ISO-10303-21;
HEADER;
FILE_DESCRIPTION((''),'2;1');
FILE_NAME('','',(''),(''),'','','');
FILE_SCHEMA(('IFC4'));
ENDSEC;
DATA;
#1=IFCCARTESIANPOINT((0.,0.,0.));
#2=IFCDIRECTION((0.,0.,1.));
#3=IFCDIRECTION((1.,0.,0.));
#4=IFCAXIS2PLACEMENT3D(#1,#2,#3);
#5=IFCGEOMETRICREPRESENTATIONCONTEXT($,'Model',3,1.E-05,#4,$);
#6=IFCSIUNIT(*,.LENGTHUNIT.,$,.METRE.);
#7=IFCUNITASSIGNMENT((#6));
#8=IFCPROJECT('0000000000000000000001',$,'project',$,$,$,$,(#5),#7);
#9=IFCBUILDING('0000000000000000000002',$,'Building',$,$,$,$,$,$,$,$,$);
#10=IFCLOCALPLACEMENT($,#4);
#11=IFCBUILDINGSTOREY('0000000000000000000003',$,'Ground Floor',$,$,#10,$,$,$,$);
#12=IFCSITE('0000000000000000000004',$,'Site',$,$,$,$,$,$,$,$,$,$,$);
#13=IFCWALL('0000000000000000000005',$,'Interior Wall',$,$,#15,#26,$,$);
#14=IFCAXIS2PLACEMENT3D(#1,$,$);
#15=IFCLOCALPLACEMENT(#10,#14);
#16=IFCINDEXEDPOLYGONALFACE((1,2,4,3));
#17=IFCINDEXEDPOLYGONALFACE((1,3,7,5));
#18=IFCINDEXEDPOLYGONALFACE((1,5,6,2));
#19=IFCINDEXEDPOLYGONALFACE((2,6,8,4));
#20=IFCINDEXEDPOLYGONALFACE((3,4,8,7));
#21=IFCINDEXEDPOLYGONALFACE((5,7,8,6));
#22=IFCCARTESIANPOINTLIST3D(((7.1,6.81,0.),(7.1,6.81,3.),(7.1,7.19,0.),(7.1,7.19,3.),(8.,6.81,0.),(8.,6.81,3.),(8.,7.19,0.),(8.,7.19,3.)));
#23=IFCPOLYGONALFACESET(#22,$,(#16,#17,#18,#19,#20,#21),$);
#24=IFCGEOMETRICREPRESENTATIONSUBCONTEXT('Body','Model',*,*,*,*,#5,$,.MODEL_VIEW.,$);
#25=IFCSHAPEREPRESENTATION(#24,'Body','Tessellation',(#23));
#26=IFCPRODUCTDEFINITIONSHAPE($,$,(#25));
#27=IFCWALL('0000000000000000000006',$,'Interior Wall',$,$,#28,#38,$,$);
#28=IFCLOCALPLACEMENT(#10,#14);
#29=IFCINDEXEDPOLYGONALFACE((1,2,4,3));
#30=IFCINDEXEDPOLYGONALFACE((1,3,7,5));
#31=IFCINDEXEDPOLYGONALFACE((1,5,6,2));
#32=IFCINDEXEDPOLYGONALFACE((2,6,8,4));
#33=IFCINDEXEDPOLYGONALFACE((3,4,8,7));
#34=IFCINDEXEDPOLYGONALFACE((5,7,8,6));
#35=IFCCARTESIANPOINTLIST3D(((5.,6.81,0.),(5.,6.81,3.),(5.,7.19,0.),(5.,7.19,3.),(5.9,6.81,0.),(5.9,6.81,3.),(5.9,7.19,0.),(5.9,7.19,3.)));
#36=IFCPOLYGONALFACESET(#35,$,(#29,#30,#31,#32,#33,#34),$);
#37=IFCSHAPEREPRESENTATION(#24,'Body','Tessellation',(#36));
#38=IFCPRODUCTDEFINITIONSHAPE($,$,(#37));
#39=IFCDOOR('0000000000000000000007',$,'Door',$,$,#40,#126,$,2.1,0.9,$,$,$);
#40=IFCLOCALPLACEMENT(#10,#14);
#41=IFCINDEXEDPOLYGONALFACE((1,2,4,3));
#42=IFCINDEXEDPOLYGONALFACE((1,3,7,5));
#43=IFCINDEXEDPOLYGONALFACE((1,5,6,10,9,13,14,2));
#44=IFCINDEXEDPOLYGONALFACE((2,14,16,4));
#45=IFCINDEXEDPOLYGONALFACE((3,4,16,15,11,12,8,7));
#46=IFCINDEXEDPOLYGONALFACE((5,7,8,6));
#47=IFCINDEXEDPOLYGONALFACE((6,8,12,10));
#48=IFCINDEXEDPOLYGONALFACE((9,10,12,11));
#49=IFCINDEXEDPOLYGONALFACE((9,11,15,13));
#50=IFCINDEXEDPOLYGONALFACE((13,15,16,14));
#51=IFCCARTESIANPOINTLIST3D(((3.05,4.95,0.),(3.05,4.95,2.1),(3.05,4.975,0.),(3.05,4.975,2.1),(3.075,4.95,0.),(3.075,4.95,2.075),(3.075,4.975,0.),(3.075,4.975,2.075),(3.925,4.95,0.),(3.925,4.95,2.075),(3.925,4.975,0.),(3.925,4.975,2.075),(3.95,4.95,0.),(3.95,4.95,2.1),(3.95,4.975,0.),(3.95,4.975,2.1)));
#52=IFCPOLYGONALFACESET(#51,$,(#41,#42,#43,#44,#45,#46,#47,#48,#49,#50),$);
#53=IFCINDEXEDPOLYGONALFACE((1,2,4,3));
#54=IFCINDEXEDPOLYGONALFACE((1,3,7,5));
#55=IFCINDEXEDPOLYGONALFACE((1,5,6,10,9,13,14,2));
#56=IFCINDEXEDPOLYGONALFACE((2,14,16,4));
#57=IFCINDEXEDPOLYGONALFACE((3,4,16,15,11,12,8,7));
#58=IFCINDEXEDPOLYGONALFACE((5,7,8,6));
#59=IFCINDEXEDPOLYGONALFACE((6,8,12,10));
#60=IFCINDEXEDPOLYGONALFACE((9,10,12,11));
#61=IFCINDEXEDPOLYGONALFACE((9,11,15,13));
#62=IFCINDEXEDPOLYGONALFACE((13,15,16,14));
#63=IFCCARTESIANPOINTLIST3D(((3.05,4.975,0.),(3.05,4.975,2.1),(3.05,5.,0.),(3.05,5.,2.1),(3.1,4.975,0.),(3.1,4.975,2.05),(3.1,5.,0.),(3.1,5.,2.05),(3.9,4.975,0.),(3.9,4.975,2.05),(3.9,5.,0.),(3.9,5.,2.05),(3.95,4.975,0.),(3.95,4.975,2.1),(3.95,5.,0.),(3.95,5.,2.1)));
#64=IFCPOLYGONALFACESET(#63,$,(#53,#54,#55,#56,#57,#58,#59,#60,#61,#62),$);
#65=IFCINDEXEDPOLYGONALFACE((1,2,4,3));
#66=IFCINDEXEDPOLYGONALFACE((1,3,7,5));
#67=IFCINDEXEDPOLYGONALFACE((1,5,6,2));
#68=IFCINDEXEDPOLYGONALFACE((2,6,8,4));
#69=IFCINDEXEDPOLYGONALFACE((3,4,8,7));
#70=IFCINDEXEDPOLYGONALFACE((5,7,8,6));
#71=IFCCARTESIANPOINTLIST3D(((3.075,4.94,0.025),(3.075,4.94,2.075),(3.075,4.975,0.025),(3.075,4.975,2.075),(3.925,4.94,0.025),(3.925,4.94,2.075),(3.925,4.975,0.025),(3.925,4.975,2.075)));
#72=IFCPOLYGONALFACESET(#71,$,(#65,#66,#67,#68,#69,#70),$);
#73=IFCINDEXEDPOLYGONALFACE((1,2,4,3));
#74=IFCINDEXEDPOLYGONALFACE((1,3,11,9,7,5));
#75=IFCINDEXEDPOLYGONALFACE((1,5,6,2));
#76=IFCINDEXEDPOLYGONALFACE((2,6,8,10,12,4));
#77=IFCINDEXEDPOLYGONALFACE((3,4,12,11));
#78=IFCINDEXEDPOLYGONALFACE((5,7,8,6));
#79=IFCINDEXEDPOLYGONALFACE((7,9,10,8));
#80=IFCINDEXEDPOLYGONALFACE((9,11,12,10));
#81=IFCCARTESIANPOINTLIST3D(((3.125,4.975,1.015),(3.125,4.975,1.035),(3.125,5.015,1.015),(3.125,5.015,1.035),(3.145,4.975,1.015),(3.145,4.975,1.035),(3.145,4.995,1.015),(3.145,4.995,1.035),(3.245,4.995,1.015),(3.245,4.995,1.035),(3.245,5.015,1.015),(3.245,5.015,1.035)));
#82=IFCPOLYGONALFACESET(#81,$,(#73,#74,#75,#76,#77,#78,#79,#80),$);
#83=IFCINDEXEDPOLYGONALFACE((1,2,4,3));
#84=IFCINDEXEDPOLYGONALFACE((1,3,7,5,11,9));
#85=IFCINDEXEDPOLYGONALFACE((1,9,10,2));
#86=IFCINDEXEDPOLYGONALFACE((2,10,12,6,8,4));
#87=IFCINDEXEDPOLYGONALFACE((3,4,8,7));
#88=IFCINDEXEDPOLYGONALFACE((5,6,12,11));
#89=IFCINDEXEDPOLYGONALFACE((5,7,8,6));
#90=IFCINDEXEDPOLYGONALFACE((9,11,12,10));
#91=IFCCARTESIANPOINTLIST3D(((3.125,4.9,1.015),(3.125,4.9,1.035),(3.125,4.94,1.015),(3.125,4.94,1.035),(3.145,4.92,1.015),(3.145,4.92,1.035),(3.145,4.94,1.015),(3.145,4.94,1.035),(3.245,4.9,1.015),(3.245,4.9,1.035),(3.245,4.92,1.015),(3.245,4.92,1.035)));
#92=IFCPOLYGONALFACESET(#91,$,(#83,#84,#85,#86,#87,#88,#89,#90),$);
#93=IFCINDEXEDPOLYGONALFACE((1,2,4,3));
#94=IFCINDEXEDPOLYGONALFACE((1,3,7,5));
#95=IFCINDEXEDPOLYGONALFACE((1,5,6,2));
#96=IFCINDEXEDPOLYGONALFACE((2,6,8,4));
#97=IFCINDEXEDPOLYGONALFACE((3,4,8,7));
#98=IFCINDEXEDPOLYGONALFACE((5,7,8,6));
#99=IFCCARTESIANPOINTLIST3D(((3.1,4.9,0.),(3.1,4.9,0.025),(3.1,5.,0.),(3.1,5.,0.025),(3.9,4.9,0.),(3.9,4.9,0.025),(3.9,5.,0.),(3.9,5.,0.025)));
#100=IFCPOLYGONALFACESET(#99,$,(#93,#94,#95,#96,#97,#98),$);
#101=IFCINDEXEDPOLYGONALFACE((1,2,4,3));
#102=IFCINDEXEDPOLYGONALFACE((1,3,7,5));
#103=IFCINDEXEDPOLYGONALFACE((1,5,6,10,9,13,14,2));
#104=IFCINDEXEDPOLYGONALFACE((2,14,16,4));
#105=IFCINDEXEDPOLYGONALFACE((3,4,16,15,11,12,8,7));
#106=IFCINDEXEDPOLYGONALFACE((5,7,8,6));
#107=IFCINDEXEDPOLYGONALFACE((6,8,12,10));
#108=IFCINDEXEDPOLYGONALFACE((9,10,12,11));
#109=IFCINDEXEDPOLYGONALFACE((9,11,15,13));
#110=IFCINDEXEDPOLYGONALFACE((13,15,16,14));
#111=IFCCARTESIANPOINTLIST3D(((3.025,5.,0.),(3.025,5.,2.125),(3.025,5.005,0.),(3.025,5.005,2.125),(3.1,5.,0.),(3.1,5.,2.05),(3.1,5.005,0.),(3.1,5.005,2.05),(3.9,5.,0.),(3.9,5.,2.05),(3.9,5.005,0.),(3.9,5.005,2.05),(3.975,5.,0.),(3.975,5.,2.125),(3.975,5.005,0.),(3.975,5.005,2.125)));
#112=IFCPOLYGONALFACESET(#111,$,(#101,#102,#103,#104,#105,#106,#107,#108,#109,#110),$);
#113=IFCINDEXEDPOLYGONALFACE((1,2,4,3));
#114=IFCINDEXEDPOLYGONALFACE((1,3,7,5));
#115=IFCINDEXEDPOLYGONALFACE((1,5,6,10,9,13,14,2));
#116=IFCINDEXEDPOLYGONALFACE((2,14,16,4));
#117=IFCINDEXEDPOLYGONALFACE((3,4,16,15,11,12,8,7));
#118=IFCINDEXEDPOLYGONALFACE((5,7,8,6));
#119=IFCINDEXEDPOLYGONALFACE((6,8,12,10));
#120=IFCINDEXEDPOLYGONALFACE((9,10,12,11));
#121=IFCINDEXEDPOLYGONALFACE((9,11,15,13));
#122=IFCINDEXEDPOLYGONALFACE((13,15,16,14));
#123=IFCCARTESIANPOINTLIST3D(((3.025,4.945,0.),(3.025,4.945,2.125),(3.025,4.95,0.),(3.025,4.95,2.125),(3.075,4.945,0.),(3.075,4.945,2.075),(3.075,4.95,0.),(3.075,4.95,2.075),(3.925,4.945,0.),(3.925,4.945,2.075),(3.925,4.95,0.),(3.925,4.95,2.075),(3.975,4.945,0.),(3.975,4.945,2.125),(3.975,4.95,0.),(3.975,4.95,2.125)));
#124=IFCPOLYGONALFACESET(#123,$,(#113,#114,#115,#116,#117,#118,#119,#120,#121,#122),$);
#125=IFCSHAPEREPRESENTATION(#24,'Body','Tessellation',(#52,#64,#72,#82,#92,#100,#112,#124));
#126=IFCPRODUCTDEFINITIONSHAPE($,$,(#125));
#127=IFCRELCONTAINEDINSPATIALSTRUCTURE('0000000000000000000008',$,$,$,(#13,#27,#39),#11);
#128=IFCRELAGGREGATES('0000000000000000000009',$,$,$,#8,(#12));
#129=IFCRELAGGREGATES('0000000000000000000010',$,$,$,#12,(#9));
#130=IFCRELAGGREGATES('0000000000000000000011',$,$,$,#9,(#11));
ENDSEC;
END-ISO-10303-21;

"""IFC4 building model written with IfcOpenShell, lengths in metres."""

from ifc_helpers import new_model, si_unit, frame, origin_with_axes, place, context, subcontext, project, spatial, line, indexed_curve, outline, extrude, element, save


model = new_model("IFC4")

# Units and contexts
model_context = context("Model", 3, precision=1e-05, world=origin_with_axes())
body_context = subcontext(model_context, "Body", "Model", "MODEL_VIEW")
ifc_project = project(units=[si_unit("LENGTHUNIT", "METRE")], contexts=[model_context])

# Site, building, storey
site = spatial("IfcSite", under=ifc_project, Name="Site")
building = spatial("IfcBuilding", under=site, Name="Building")
storey_placement = place(None, origin_with_axes())
storey = spatial("IfcBuildingStorey", under=building, at=storey_placement, Name="Ground Floor")

# Walls
for number, where, z_axis, x_axis, name in (
    (1, (8.0, 7.0, 0.0), (0.0, 0.0, 1.0), (-1.0, 0.0, 0.0), "Interior Wall"),
    (2, (5.9, 7.0, 0.0), (0.0, 0.0, 1.0), (-1.0, 0.0, 0.0), "Interior Wall"),
):
    element("IfcWall", number, at=place(storey_placement, frame(where, z_axis=z_axis, x_axis=x_axis)), inside=storey, Name=name, context=body_context, shape_type="SweptSolid", body=[
        extrude(outline(indexed_curve([(0.0, 0.0), (0.0, 0.38), (0.9, 0.38), (0.9, 0.0), (0.0, 0.0)], self_intersect=False)), frame((0.0, -0.19, 0.0), z_axis=(0.0, 0.0, 1.0), x_axis=(1.0, 0.0, 0.0)), (0.0, 0.0, 1.0), 3.0),
    ])

# Door
door_1_placement = place(storey_placement, frame((3.95, 5.0, 0.0), z_axis=(0.0, 0.0, 1.0), x_axis=(-1.0, 0.0, 0.0)))
element("IfcDoor", 3, at=door_1_placement, inside=storey, Name="Door", OverallHeight=2.1, OverallWidth=0.9, context=body_context, shape_type="SweptSolid", body=[
    extrude(outline(indexed_curve([(0.0, 0.0), (0.0, 2.1), (0.9, 2.1), (0.9, 0.0), (0.875, 0.0), (0.875, 2.075), (0.025, 2.075), (0.025, 0.0)], segments=[line(1, 2, 3, 4, 5, 6, 7, 8, 1)])), frame((0.0, 0.025, 0.0), z_axis=(0.0, -1.0, 0.0), x_axis=(1.0, 0.0, 0.0)), (0.0, 0.0, -1.0), 0.025),
    extrude(outline(indexed_curve([(0.0, 0.0), (0.0, 2.1), (0.9, 2.1), (0.9, 0.0), (0.85, 0.0), (0.85, 2.05), (0.05, 2.05), (0.05, 0.0)], segments=[line(1, 2, 3, 4, 5, 6, 7, 8, 1)])), frame((0.0, 0.0, 0.0), z_axis=(0.0, -1.0, 0.0), x_axis=(1.0, 0.0, 0.0)), (0.0, 0.0, -1.0), 0.025),
    extrude(outline(indexed_curve([(0.0, 0.0), (0.85, 0.0), (0.85, 0.035), (0.0, 0.035)], segments=[line(1, 2, 3, 4, 1)])), frame((0.025, 0.025, 0.025), z_axis=(0.0, 0.0, 1.0), x_axis=(1.0, 0.0, 0.0)), (0.0, 0.0, 1.0), 2.05),
    extrude(outline(indexed_curve([(0.0, 0.0), (0.0, -0.04), (-0.12, -0.04), (-0.12, -0.02), (-0.02, -0.02), (-0.02, 0.0)], segments=[line(1, 2, 3, 4, 5, 6, 1)])), frame((0.825, 0.025, 1.015), z_axis=(0.0, 0.0, 1.0), x_axis=(1.0, 0.0, 0.0)), (0.0, 0.0, 1.0), 0.02),
    extrude(outline(indexed_curve([(0.0, 0.0), (0.0, 0.04), (-0.12, 0.04), (-0.12, 0.02), (-0.02, 0.02), (-0.02, 0.0)], segments=[line(1, 2, 3, 4, 5, 6, 1)])), frame((0.825, 0.06, 1.015), z_axis=(0.0, 0.0, 1.0), x_axis=(1.0, 0.0, 0.0)), (0.0, 0.0, 1.0), 0.02),
    extrude(outline(indexed_curve([(0.0, 0.0), (0.8, 0.0), (0.8, 0.1), (0.0, 0.1)], segments=[line(1, 2, 3, 4, 1)])), frame((0.05, 0.0, 0.0), z_axis=(0.0, 0.0, 1.0), x_axis=(1.0, 0.0, 0.0)), (0.0, 0.0, 1.0), 0.025),
    extrude(outline(indexed_curve([(0.0, 0.0), (0.0, 2.125), (0.95, 2.125), (0.95, 0.0), (0.875, 0.0), (0.875, 2.05), (0.075, 2.05), (0.075, 0.0)], segments=[line(1, 2, 3, 4, 5, 6, 7, 8, 1)])), frame((-0.025, -0.005, 0.0), z_axis=(0.0, -1.0, 0.0), x_axis=(1.0, 0.0, 0.0)), (0.0, 0.0, -1.0), 0.005),
    extrude(outline(indexed_curve([(0.0, 0.0), (0.0, 2.125), (0.95, 2.125), (0.95, 0.0), (0.9, 0.0), (0.9, 2.075), (0.05, 2.075), (0.05, 0.0)], segments=[line(1, 2, 3, 4, 5, 6, 7, 8, 1)])), frame((-0.025, 0.05, 0.0), z_axis=(0.0, -1.0, 0.0), x_axis=(1.0, 0.0, 0.0)), (0.0, 0.0, -1.0), 0.005),
])

save(model, "model.ifc")
